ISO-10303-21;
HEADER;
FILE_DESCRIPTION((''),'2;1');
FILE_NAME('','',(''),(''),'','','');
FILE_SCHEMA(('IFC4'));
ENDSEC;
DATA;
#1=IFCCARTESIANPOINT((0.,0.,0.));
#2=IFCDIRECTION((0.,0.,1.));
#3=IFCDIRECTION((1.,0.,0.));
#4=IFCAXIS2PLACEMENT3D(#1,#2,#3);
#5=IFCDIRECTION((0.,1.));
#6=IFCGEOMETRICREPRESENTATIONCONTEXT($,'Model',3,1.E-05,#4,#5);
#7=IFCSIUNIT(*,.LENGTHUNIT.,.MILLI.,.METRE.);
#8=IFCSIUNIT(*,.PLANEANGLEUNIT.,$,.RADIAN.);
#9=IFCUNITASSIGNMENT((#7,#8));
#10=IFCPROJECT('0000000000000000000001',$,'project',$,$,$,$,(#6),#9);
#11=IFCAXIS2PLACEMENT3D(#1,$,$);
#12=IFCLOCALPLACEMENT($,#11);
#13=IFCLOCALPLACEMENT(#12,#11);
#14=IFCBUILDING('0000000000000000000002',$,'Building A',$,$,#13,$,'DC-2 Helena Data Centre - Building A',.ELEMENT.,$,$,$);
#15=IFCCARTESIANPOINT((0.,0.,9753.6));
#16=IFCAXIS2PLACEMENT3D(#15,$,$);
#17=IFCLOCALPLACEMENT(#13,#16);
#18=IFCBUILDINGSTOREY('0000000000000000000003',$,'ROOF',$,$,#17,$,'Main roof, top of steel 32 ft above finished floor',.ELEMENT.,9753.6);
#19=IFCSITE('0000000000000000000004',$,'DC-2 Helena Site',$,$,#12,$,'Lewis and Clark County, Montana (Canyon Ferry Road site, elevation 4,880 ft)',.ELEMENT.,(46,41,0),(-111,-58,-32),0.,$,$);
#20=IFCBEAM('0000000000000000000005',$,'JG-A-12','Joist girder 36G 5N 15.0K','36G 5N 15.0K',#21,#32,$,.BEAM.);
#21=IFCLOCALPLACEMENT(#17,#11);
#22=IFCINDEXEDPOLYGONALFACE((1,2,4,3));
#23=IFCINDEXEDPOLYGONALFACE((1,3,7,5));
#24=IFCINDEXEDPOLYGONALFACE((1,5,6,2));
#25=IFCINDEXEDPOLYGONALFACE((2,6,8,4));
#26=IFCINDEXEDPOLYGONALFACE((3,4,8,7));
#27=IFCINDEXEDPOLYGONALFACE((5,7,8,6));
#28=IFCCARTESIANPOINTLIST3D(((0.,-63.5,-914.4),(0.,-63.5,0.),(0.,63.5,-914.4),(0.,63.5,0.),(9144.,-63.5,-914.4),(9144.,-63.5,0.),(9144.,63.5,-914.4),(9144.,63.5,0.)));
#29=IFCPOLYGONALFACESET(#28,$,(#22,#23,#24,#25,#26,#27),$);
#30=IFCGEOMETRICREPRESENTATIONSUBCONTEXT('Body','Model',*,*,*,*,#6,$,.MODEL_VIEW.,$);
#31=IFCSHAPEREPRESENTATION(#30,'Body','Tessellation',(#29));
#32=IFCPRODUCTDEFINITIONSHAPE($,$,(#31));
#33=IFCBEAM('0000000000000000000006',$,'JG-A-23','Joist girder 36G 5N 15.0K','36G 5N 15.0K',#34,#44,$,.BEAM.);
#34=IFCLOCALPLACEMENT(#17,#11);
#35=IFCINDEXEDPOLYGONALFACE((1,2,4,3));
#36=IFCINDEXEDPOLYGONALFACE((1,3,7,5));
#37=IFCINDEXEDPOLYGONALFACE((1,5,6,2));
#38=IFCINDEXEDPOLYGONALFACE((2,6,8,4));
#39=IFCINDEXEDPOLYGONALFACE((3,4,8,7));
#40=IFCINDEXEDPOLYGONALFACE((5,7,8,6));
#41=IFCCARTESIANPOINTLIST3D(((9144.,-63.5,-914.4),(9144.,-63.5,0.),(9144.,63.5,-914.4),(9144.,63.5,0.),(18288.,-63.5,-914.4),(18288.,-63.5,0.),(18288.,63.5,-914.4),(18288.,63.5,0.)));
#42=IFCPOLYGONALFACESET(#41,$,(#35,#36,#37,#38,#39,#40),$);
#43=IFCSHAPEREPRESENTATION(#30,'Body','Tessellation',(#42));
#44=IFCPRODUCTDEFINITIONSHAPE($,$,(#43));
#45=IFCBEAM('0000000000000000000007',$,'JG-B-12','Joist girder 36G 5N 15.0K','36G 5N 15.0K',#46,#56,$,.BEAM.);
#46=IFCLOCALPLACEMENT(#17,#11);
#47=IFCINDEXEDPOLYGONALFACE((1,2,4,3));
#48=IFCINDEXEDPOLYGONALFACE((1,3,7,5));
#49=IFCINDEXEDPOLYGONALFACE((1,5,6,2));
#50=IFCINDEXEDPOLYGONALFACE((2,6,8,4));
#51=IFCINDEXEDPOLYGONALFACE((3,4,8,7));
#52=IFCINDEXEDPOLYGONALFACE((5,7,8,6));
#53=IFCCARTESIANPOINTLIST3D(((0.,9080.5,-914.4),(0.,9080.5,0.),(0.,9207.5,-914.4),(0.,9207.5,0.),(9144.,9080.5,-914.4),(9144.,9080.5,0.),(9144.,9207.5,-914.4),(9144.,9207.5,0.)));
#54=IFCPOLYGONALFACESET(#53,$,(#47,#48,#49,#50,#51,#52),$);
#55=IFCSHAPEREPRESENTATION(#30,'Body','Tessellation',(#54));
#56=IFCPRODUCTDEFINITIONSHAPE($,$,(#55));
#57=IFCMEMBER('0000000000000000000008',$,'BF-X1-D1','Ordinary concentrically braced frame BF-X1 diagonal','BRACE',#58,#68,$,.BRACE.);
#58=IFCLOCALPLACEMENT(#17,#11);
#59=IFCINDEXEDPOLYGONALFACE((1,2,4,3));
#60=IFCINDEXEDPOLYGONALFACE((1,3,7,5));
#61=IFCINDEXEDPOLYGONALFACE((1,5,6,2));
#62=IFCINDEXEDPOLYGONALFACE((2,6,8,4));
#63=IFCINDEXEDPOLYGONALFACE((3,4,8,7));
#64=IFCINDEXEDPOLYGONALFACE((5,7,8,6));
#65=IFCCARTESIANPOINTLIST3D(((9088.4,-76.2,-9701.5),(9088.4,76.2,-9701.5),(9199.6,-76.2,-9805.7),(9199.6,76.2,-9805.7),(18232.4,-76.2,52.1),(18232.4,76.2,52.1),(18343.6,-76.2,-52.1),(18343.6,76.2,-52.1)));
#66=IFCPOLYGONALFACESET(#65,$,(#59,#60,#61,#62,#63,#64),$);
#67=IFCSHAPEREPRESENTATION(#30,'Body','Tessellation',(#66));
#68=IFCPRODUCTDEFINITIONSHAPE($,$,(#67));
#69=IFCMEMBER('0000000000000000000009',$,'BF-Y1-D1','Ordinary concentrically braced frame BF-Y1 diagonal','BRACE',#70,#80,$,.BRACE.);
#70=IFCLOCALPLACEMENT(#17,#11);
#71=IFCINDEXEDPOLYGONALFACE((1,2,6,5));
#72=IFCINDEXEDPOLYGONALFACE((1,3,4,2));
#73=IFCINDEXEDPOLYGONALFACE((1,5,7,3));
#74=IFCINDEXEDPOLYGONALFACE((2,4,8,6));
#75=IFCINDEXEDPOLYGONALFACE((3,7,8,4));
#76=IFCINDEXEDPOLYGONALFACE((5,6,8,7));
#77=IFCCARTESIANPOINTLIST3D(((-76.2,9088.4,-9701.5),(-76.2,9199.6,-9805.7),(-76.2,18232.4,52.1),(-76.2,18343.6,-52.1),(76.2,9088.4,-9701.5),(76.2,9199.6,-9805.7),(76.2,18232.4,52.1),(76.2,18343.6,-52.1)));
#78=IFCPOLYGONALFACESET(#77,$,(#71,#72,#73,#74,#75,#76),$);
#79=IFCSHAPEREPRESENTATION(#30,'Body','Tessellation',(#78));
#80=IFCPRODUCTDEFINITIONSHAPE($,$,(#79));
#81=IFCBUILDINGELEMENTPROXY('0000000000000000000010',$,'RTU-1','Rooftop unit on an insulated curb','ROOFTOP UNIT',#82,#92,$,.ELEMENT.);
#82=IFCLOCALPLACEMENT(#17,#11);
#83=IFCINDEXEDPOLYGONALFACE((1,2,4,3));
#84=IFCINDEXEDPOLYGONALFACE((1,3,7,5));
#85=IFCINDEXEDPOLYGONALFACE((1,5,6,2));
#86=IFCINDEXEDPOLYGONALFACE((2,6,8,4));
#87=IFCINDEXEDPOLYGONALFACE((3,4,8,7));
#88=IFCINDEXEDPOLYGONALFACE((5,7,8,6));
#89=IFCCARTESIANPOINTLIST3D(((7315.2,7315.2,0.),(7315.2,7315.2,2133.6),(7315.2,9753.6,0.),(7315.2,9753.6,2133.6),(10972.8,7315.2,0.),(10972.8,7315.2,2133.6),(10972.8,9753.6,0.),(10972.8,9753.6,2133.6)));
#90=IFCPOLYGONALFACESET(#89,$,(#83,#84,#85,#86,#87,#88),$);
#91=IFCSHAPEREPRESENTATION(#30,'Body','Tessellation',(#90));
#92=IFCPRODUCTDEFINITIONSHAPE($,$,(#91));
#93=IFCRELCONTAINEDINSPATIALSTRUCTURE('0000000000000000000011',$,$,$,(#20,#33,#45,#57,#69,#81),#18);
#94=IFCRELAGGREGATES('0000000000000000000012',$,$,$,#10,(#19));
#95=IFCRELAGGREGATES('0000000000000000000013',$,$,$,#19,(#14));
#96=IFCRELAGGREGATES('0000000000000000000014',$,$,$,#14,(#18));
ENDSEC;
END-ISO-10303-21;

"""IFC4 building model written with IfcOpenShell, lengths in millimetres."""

from ifc_helpers import new_model, si_unit, direction, frame, origin, origin_with_axes, origin_2d, place, context, subcontext, project, spatial, rectangle, extrude, element, save


model = new_model("IFC4")

# Units and contexts
model_context = context("Model", 3, precision=1e-05, world=origin_with_axes(), true_north=direction((0.0, 1.0)))
body_context = subcontext(model_context, "Body", "Model", "MODEL_VIEW")
ifc_project = project(units=[si_unit("LENGTHUNIT", "METRE", prefix="MILLI"), si_unit("PLANEANGLEUNIT", "RADIAN")], contexts=[model_context])

# Site, building, storey
site_placement = place(None, origin())
site = spatial("IfcSite", under=ifc_project, at=site_placement, Name="DC-2 Helena Site", LongName="Lewis and Clark County, Montana (Canyon Ferry Road site, elevation 4,880 ft)", CompositionType="ELEMENT", RefLatitude=(46, 41, 0), RefLongitude=(-111, -58, -32), RefElevation=0.0)
building_placement = place(site_placement, origin())
building = spatial("IfcBuilding", under=site, at=building_placement, Name="Building A", LongName="DC-2 Helena Data Centre - Building A", CompositionType="ELEMENT")
storey_placement = place(building_placement, frame((0.0, 0.0, 9753.6)))
storey = spatial("IfcBuildingStorey", under=building, at=storey_placement, Name="ROOF", LongName="Main roof, top of steel 32 ft above finished floor", CompositionType="ELEMENT", Elevation=9753.6)

# Shared definitions
placement_1 = place(storey_placement, frame((0.0, 9144.0, -9753.6)))
placement_2 = place(storey_placement, frame((9144.0, 0.0, -9753.6)))

# Beams
placement_3 = place(storey_placement, origin())
placement_4 = place(storey_placement, frame((0.0, 9144.0, 0.0)))
placement_5 = place(storey_placement, frame((9144.0, 0.0, 0.0)))
element("IfcBeam", 1, at=placement_3, inside=storey, Name="JG-A-12", Description="Joist girder 36G 5N 15.0K", ObjectType="36G 5N 15.0K", PredefinedType="BEAM", context=body_context, shape_type="SweptSolid", body=[
    extrude(rectangle(XDim=127.0, YDim=914.4, at=origin_2d()), frame((0.0, 0.0, -457.2), z_axis=(1.0, 0.0, 0.0), x_axis=(0.0, 1.0, 0.0)), (0.0, 0.0, 1.0), 9144.0),
])
element("IfcBeam", 2, at=placement_5, inside=storey, Name="JG-A-23", Description="Joist girder 36G 5N 15.0K", ObjectType="36G 5N 15.0K", PredefinedType="BEAM", context=body_context, shape_type="SweptSolid", body=[
    extrude(rectangle(XDim=127.0, YDim=914.4, at=origin_2d()), frame((0.0, 0.0, -457.2), z_axis=(1.0, 0.0, 0.0), x_axis=(0.0, 1.0, 0.0)), (0.0, 0.0, 1.0), 9144.0),
])
element("IfcBeam", 3, at=placement_4, inside=storey, Name="JG-B-12", Description="Joist girder 36G 5N 15.0K", ObjectType="36G 5N 15.0K", PredefinedType="BEAM", context=body_context, shape_type="SweptSolid", body=[
    extrude(rectangle(XDim=127.0, YDim=914.4, at=origin_2d()), frame((0.0, 0.0, -457.2), z_axis=(1.0, 0.0, 0.0), x_axis=(0.0, 1.0, 0.0)), (0.0, 0.0, 1.0), 9144.0),
])

# Members
element("IfcMember", 4, at=placement_2, inside=storey, Name="BF-X1-D1", Description="Ordinary concentrically braced frame BF-X1 diagonal", ObjectType="BRACE", PredefinedType="BRACE", context=body_context, shape_type="SweptSolid", body=[
    extrude(rectangle(XDim=152.4, YDim=152.4, at=origin_2d()), frame((0.0, 0.0, 0.0), z_axis=(0.683941, 0.0, 0.729537), x_axis=(0.0, 1.0, 0.0)), (0.0, 0.0, 1.0), 13369.6),
])
element("IfcMember", 5, at=placement_1, inside=storey, Name="BF-Y1-D1", Description="Ordinary concentrically braced frame BF-Y1 diagonal", ObjectType="BRACE", PredefinedType="BRACE", context=body_context, shape_type="SweptSolid", body=[
    extrude(rectangle(XDim=152.4, YDim=152.4, at=origin_2d()), frame((0.0, 0.0, 0.0), z_axis=(0.0, 0.683941, 0.729537), x_axis=(1.0, 0.0, 0.0)), (0.0, 0.0, 1.0), 13369.6),
])

# Building element proxy
proxy_placement = place(storey_placement, frame((9144.0, 8534.4, 0.0)))
element("IfcBuildingElementProxy", 6, at=proxy_placement, inside=storey, Name="RTU-1", Description="Rooftop unit on an insulated curb", ObjectType="ROOFTOP UNIT", PredefinedType="ELEMENT", context=body_context, shape_type="SweptSolid", body=[
    extrude(rectangle(XDim=3657.6, YDim=2438.4, at=origin_2d()), origin(), (0.0, 0.0, 1.0), 2133.6),
])

save(model, "model.ifc")
